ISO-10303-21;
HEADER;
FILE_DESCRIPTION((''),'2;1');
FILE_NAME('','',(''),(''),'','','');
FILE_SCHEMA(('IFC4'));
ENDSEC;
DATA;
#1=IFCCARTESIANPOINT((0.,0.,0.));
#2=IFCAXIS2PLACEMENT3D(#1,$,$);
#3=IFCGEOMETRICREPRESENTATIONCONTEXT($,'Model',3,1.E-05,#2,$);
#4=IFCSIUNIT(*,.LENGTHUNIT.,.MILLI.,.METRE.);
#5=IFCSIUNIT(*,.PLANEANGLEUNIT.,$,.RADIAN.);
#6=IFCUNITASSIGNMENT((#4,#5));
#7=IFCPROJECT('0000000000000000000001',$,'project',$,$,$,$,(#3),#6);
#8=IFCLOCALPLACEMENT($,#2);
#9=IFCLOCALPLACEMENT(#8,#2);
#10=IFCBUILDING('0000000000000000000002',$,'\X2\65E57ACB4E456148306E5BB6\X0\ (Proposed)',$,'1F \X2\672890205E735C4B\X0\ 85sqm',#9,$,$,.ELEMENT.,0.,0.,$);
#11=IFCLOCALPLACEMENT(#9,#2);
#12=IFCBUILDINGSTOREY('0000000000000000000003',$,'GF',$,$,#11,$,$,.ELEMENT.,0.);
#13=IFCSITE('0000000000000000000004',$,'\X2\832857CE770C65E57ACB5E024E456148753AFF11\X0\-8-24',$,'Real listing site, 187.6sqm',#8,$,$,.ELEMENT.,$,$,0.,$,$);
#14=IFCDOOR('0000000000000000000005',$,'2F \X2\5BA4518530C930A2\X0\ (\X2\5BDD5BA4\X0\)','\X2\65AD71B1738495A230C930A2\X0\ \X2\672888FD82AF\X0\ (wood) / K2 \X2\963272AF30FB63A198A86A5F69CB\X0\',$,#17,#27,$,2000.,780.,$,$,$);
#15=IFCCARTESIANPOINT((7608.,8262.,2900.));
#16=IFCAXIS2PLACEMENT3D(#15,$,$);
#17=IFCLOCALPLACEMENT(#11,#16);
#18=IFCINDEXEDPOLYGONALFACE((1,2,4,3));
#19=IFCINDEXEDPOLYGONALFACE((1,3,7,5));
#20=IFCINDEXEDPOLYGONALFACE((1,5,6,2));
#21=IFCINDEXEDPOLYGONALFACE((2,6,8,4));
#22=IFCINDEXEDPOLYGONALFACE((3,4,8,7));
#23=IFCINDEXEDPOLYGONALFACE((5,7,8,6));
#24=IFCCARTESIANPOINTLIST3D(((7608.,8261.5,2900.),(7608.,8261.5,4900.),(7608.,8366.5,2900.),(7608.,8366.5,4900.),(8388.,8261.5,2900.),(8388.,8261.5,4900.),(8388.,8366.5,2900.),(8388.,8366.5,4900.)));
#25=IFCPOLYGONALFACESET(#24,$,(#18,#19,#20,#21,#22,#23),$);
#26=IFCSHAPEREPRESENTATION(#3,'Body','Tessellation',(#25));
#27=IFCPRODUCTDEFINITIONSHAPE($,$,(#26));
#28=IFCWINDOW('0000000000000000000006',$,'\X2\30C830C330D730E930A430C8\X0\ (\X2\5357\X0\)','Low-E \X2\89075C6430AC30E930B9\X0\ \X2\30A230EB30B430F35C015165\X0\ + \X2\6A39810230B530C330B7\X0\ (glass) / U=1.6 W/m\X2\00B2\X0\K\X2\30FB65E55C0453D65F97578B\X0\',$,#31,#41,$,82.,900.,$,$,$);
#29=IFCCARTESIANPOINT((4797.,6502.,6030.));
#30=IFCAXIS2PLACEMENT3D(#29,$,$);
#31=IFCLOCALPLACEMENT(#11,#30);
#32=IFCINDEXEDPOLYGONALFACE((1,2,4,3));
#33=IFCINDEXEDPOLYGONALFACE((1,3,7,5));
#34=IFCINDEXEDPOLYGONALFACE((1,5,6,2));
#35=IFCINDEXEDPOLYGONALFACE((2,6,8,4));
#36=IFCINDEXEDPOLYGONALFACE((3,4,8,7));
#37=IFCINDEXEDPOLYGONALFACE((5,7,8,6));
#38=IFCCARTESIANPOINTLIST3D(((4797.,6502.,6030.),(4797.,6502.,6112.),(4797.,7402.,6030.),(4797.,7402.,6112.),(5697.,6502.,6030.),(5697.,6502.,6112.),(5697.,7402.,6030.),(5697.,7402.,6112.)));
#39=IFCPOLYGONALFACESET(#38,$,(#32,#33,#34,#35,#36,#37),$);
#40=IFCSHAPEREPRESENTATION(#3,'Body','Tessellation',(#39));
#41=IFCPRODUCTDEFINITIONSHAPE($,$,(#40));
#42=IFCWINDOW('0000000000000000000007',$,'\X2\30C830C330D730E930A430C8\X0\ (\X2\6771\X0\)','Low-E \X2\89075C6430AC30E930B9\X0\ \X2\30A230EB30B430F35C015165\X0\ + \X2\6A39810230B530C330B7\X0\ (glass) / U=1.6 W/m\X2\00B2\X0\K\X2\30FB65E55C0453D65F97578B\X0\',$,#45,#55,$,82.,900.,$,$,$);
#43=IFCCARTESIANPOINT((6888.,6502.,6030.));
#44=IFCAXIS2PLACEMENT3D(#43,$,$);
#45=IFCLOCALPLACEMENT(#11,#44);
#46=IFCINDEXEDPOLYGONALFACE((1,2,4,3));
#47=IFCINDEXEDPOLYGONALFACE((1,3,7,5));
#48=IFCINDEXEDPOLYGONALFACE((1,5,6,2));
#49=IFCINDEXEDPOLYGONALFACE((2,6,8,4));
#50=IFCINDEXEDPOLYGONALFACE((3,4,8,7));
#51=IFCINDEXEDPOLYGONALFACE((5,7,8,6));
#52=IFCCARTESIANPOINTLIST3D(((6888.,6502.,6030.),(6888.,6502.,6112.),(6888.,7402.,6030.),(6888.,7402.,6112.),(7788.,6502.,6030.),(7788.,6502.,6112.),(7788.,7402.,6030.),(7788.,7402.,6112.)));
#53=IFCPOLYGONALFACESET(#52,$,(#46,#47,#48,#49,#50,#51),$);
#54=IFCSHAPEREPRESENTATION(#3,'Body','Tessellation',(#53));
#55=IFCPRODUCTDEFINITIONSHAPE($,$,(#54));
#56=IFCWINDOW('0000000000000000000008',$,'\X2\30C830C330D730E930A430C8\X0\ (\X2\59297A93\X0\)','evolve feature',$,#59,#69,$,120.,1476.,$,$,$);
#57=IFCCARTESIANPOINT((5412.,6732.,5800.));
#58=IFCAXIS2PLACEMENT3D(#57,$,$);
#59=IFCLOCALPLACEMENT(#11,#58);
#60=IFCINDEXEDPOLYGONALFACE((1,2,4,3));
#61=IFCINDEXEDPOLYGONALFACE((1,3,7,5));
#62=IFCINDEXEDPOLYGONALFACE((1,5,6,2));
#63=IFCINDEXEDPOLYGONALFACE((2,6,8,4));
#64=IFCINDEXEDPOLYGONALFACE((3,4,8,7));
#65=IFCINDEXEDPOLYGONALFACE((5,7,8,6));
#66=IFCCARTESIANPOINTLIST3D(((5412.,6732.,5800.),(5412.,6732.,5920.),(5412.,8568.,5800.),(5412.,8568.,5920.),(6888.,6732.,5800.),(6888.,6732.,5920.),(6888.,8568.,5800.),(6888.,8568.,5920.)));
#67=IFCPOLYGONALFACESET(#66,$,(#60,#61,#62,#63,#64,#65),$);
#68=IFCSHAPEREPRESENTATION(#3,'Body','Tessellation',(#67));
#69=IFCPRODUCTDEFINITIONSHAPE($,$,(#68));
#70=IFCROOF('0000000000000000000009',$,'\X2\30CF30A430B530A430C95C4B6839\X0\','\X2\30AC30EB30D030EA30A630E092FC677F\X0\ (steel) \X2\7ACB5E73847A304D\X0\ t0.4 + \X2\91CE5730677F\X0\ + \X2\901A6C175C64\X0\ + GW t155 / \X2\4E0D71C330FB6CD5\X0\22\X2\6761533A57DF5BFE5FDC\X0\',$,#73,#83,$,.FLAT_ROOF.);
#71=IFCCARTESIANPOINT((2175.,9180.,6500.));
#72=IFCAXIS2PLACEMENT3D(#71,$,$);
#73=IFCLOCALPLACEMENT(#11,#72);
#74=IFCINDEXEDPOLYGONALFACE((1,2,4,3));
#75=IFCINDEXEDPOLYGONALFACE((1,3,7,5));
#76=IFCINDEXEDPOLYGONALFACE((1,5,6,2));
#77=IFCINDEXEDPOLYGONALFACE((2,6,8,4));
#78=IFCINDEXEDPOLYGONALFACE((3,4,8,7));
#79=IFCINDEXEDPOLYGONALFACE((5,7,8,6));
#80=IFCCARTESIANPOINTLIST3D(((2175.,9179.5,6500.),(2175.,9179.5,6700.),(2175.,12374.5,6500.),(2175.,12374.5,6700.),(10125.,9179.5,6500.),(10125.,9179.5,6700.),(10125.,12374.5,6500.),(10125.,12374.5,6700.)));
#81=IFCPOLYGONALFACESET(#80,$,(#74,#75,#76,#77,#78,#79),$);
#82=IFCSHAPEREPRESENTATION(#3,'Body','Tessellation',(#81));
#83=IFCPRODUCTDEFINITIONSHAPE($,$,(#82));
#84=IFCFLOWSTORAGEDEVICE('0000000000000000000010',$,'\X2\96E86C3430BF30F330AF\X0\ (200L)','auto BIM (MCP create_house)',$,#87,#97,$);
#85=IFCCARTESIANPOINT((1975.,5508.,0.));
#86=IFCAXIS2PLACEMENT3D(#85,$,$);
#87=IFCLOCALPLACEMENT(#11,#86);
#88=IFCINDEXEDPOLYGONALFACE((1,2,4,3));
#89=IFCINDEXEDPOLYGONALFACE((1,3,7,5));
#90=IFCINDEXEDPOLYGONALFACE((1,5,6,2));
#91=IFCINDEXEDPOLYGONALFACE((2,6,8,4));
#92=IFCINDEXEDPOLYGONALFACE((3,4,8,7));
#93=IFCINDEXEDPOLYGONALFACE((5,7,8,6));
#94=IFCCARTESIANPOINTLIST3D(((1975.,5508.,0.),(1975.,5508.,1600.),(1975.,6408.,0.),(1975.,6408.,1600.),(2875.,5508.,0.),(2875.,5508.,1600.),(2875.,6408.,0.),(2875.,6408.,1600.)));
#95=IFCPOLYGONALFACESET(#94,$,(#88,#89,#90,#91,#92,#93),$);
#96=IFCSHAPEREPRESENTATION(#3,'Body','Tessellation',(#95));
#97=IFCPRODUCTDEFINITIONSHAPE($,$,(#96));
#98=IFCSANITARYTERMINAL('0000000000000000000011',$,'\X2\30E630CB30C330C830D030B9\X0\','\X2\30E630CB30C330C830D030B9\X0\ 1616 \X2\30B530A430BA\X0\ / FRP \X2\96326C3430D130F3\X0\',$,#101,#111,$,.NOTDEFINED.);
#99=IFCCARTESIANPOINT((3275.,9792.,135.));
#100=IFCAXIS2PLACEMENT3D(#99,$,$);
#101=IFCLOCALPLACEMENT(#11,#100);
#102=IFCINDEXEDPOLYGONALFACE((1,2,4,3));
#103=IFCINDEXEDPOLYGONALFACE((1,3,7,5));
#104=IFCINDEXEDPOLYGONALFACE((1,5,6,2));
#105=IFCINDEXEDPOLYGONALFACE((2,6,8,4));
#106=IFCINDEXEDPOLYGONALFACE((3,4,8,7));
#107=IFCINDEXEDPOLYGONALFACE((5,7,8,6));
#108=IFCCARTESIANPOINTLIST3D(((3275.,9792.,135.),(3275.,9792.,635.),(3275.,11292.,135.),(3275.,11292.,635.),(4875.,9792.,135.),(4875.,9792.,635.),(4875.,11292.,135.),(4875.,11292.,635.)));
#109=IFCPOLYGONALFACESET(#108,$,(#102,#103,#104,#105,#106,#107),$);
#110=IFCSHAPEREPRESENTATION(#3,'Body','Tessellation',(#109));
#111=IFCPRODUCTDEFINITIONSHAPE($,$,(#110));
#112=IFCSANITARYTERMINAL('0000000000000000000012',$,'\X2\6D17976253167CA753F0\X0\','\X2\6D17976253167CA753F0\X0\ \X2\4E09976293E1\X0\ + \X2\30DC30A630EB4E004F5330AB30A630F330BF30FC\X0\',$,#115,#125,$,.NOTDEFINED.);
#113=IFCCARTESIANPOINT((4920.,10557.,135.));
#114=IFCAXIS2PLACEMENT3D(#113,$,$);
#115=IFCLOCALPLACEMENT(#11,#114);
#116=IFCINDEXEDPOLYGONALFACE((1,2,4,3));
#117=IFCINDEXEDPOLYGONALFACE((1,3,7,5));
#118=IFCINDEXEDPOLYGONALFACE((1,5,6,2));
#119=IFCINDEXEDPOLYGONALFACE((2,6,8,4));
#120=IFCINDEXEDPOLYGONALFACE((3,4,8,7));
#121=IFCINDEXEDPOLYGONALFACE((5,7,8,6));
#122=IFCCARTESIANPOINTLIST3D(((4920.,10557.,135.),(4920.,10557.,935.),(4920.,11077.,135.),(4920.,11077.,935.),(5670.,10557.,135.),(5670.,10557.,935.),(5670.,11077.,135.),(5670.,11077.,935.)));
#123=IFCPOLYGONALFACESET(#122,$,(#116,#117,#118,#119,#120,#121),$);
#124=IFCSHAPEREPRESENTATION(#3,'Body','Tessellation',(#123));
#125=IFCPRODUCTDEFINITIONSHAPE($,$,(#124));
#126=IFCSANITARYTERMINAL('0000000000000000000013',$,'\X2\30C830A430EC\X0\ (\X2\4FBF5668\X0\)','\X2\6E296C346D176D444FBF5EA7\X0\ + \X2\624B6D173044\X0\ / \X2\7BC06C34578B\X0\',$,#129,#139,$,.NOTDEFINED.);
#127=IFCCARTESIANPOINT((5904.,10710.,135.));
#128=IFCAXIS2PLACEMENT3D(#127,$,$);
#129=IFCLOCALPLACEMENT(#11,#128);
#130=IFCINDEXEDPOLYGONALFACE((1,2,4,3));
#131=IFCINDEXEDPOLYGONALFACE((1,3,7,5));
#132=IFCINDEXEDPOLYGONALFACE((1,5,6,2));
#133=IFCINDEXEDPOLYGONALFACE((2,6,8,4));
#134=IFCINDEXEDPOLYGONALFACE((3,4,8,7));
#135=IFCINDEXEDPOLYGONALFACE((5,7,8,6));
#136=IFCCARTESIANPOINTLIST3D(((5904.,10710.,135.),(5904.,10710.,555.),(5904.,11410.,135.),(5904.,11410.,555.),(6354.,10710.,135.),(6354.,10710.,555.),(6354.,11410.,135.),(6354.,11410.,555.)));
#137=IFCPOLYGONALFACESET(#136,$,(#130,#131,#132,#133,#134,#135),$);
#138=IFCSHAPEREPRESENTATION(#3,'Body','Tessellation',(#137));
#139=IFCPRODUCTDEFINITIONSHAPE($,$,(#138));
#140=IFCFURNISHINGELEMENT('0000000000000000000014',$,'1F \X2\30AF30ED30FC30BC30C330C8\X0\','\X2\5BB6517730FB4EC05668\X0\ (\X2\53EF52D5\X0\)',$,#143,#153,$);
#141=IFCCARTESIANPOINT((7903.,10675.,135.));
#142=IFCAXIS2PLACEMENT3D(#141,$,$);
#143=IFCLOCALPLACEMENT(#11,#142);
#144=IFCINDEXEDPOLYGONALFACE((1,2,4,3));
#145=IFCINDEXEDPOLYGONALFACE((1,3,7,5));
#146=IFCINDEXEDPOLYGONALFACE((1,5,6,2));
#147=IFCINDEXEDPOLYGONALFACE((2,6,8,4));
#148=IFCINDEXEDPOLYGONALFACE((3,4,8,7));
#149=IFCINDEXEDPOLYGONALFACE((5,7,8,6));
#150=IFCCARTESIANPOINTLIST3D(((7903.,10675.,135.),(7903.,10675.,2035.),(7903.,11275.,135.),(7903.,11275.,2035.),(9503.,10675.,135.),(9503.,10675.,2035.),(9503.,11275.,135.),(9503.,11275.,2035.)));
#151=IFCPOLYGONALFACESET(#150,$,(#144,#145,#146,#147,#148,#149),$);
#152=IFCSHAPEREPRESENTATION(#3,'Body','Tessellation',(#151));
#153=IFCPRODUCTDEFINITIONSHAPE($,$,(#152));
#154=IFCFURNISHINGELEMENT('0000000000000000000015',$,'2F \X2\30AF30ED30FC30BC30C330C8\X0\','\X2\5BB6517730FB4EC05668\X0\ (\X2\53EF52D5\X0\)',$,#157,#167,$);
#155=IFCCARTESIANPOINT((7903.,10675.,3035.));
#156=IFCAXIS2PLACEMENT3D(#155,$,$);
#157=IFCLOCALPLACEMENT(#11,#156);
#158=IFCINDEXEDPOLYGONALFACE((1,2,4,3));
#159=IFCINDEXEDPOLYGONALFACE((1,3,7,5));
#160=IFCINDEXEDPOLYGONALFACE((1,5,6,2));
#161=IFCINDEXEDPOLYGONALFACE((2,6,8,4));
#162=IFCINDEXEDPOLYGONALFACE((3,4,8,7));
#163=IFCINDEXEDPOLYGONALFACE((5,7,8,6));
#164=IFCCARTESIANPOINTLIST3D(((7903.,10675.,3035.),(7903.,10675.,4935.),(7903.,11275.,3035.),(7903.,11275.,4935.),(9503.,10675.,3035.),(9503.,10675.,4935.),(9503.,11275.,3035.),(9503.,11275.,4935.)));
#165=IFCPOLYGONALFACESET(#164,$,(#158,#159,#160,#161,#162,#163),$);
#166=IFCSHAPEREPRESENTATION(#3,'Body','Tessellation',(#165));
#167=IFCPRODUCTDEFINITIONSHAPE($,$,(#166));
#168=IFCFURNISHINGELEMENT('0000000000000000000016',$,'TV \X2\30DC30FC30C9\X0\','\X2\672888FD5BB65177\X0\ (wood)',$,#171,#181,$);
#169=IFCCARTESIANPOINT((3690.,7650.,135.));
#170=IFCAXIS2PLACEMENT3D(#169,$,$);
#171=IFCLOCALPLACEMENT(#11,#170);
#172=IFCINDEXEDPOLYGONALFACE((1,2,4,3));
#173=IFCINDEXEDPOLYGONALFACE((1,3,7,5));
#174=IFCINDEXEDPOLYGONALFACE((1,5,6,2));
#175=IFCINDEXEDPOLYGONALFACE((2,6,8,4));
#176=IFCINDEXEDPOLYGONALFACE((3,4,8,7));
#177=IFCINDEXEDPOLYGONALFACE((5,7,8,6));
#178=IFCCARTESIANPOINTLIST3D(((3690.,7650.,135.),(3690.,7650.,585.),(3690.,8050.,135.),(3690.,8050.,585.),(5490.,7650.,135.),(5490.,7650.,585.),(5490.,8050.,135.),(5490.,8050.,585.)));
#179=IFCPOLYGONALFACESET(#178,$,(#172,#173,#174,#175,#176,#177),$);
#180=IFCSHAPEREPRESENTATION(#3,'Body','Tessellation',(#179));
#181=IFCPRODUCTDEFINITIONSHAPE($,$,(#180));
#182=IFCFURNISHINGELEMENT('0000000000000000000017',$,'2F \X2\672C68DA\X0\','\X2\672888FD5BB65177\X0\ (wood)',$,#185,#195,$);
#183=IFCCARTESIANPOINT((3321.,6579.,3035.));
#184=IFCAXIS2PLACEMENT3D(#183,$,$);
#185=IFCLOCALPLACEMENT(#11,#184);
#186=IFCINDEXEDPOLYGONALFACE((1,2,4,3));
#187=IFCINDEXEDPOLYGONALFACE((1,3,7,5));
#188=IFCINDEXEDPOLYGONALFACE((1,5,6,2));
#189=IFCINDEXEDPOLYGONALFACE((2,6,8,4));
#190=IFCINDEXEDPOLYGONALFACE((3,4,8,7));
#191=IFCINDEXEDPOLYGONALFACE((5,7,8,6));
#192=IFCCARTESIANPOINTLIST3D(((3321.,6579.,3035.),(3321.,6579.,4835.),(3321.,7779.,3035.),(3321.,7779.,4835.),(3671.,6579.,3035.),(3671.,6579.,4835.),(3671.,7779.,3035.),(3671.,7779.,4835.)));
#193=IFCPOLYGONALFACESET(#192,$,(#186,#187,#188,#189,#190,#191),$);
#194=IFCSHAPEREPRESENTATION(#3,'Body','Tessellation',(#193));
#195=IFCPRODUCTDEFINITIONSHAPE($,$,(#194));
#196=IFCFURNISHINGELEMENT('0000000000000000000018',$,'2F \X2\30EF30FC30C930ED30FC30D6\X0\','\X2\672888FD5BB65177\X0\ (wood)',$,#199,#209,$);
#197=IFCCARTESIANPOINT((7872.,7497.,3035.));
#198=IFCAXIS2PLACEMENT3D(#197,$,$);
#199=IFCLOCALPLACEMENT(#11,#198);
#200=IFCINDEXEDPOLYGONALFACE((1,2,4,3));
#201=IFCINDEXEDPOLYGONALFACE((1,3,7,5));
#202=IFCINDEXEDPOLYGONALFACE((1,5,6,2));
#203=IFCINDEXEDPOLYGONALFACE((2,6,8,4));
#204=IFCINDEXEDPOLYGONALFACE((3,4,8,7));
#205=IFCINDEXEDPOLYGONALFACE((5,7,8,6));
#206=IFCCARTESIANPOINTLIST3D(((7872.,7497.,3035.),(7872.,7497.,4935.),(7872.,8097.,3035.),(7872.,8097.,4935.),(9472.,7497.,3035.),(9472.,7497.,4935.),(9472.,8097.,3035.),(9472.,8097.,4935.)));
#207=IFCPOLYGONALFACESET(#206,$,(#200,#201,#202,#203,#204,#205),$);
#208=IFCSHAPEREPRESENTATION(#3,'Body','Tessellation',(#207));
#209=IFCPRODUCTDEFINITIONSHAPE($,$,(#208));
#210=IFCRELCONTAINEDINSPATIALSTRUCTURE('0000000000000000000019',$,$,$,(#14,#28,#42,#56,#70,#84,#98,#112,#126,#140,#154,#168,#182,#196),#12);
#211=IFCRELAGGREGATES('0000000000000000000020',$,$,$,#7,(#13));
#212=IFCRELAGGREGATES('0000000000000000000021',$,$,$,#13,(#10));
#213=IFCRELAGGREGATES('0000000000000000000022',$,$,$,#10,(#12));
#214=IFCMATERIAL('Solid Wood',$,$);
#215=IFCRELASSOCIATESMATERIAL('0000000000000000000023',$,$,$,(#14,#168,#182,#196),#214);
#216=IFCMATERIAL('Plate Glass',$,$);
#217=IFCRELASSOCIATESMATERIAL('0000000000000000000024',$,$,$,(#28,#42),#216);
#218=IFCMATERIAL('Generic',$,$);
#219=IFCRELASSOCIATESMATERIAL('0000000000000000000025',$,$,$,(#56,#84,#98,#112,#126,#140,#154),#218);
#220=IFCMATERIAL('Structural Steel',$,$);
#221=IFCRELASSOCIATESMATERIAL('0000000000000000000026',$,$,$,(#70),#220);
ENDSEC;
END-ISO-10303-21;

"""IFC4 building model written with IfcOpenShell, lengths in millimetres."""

from ifc_helpers import new_model, si_unit, frame, frame_2d, origin, place, context, project, spatial, rectangle, extrude, material, element, save


model = new_model("IFC4")

# Units and contexts
model_context = context("Model", 3, precision=1e-05, world=origin())
ifc_project = project(units=[si_unit("LENGTHUNIT", "METRE", prefix="MILLI"), si_unit("PLANEANGLEUNIT", "RADIAN")], contexts=[model_context])

# Site, building, storey
site_placement = place(None, origin())
site = spatial("IfcSite", under=ifc_project, at=site_placement, Name="茨城県日立市久慈町１-8-24", ObjectType="Real listing site, 187.6sqm", CompositionType="ELEMENT", RefElevation=0.0)
building_placement = place(site_placement, origin())
building = spatial("IfcBuilding", under=site, at=building_placement, Name="日立久慈の家 (Proposed)", ObjectType="1F 木造平屋 85sqm", CompositionType="ELEMENT", ElevationOfRefHeight=0.0, ElevationOfTerrain=0.0)
storey_placement = place(building_placement, origin())
storey = spatial("IfcBuildingStorey", under=building, at=storey_placement, Name="GF", CompositionType="ELEMENT", Elevation=0.0)

# Shared definitions
ifc_material_1 = material(Name="Solid Wood")
ifc_material_2 = material(Name="Plate Glass")

# Door
door_1_placement = place(storey_placement, frame((7608.0, 8262.0, 2900.0)))
element("IfcDoor", 1, at=door_1_placement, inside=storey, material=ifc_material_1, Name="2F 室内ドア (寝室)", Description="断熱玄関ドア 木製芯 (wood) / K2 防犯・採風機構", OverallHeight=2000.0, OverallWidth=780.0, context=model_context, shape_type="SweptSolid", body=[
    extrude(rectangle(XDim=780.0, YDim=105.0, at=frame_2d((390.0, 52.0))), frame((7608.0, 8262.0, 2900.0)), (0.0, 0.0, 1.0), 2000.0),
])

# Windows
window_1_placement = place(storey_placement, frame((4797.0, 6502.0, 6030.0)))
element("IfcWindow", 2, at=window_1_placement, inside=storey, material=ifc_material_2, Name="トップライト (南)", Description="Low-E 複層ガラス アルゴン封入 + 樹脂サッシ (glass) / U=1.6 W/m²K・日射取得型", OverallHeight=82.0, OverallWidth=900.0, context=model_context, shape_type="SweptSolid", body=[
    extrude(rectangle(XDim=900.0, YDim=900.0, at=frame_2d((450.0, 450.0))), frame((4797.0, 6502.0, 6030.0)), (0.0, 0.0, 1.0), 82.0),
])
window_2_placement = place(storey_placement, frame((6888.0, 6502.0, 6030.0)))
element("IfcWindow", 3, at=window_2_placement, inside=storey, material=ifc_material_2, Name="トップライト (東)", Description="Low-E 複層ガラス アルゴン封入 + 樹脂サッシ (glass) / U=1.6 W/m²K・日射取得型", OverallHeight=82.0, OverallWidth=900.0, context=model_context, shape_type="SweptSolid", body=[
    extrude(rectangle(XDim=900.0, YDim=900.0, at=frame_2d((450.0, 450.0))), frame((6888.0, 6502.0, 6030.0)), (0.0, 0.0, 1.0), 82.0),
])
ifc_material_3 = material(Name="Generic")
window_3_placement = place(storey_placement, frame((5412.0, 6732.0, 5800.0)))
element("IfcWindow", 4, at=window_3_placement, inside=storey, material=ifc_material_3, Name="トップライト (天窓)", Description="evolve feature", OverallHeight=120.0, OverallWidth=1476.0, context=model_context, shape_type="SweptSolid", body=[
    extrude(rectangle(XDim=1476.0, YDim=1836.0, at=frame_2d((738.0, 918.0))), frame((5412.0, 6732.0, 5800.0)), (0.0, 0.0, 1.0), 120.0),
])

# Roof
ifc_material_4 = material(Name="Structural Steel")
roof_placement = place(storey_placement, frame((2175.0, 9180.0, 6500.0)))
element("IfcRoof", 5, at=roof_placement, inside=storey, material=ifc_material_4, Name="ハイサイド屋根", Description="ガルバリウム鋼板 (steel) 立平葺き t0.4 + 野地板 + 通気層 + GW t155 / 不燃・法22条区域対応", PredefinedType="FLAT_ROOF", context=model_context, shape_type="SweptSolid", body=[
    extrude(rectangle(XDim=7950.0, YDim=3195.0, at=frame_2d((3975.0, 1597.0))), frame((2175.0, 9180.0, 6500.0)), (0.0, 0.0, 1.0), 200.0),
])

# Flow storage device
flow_storage_device_placement = place(storey_placement, frame((1975.0, 5508.0, 0.0)))
element("IfcFlowStorageDevice", 6, at=flow_storage_device_placement, inside=storey, material=ifc_material_3, Name="雨水タンク (200L)", Description="auto BIM (MCP create_house)", context=model_context, shape_type="SweptSolid", body=[
    extrude(rectangle(XDim=900.0, YDim=900.0, at=frame_2d((450.0, 450.0))), frame((1975.0, 5508.0, 0.0)), (0.0, 0.0, 1.0), 1600.0),
])

# Sanitary terminals
sanitary_terminal_1_placement = place(storey_placement, frame((3275.0, 9792.0, 135.0)))
element("IfcSanitaryTerminal", 7, at=sanitary_terminal_1_placement, inside=storey, material=ifc_material_3, Name="ユニットバス", Description="ユニットバス 1616 サイズ / FRP 防水パン", PredefinedType="NOTDEFINED", context=model_context, shape_type="SweptSolid", body=[
    extrude(rectangle(XDim=1600.0, YDim=1500.0, at=frame_2d((800.0, 750.0))), frame((3275.0, 9792.0, 135.0)), (0.0, 0.0, 1.0), 500.0),
])
sanitary_terminal_2_placement = place(storey_placement, frame((4920.0, 10557.0, 135.0)))
element("IfcSanitaryTerminal", 8, at=sanitary_terminal_2_placement, inside=storey, material=ifc_material_3, Name="洗面化粧台", Description="洗面化粧台 三面鏡 + ボウル一体カウンター", PredefinedType="NOTDEFINED", context=model_context, shape_type="SweptSolid", body=[
    extrude(rectangle(XDim=750.0, YDim=520.0, at=frame_2d((375.0, 260.0))), frame((4920.0, 10557.0, 135.0)), (0.0, 0.0, 1.0), 800.0),
])
sanitary_terminal_3_placement = place(storey_placement, frame((5904.0, 10710.0, 135.0)))
element("IfcSanitaryTerminal", 9, at=sanitary_terminal_3_placement, inside=storey, material=ifc_material_3, Name="トイレ (便器)", Description="温水洗浄便座 + 手洗い / 節水型", PredefinedType="NOTDEFINED", context=model_context, shape_type="SweptSolid", body=[
    extrude(rectangle(XDim=450.0, YDim=700.0, at=frame_2d((225.0, 350.0))), frame((5904.0, 10710.0, 135.0)), (0.0, 0.0, 1.0), 420.0),
])

# Furnishing elements
furnishing_1_placement = place(storey_placement, frame((7903.0, 10675.0, 135.0)))
element("IfcFurnishingElement", 10, at=furnishing_1_placement, inside=storey, material=ifc_material_3, Name="1F クローゼット", Description="家具・什器 (可動)", context=model_context, shape_type="SweptSolid", body=[
    extrude(rectangle(XDim=1600.0, YDim=600.0, at=frame_2d((800.0, 300.0))), frame((7903.0, 10675.0, 135.0)), (0.0, 0.0, 1.0), 1900.0),
])
furnishing_2_placement = place(storey_placement, frame((7903.0, 10675.0, 3035.0)))
element("IfcFurnishingElement", 11, at=furnishing_2_placement, inside=storey, material=ifc_material_3, Name="2F クローゼット", Description="家具・什器 (可動)", context=model_context, shape_type="SweptSolid", body=[
    extrude(rectangle(XDim=1600.0, YDim=600.0, at=frame_2d((800.0, 300.0))), frame((7903.0, 10675.0, 3035.0)), (0.0, 0.0, 1.0), 1900.0),
])
furnishing_3_placement = place(storey_placement, frame((3690.0, 7650.0, 135.0)))
element("IfcFurnishingElement", 12, at=furnishing_3_placement, inside=storey, material=ifc_material_1, Name="TV ボード", Description="木製家具 (wood)", context=model_context, shape_type="SweptSolid", body=[
    extrude(rectangle(XDim=1800.0, YDim=400.0, at=frame_2d((900.0, 200.0))), frame((3690.0, 7650.0, 135.0)), (0.0, 0.0, 1.0), 450.0),
])
furnishing_4_placement = place(storey_placement, frame((3321.0, 6579.0, 3035.0)))
element("IfcFurnishingElement", 13, at=furnishing_4_placement, inside=storey, material=ifc_material_1, Name="2F 本棚", Description="木製家具 (wood)", context=model_context, shape_type="SweptSolid", body=[
    extrude(rectangle(XDim=350.0, YDim=1200.0, at=frame_2d((175.0, 600.0))), frame((3321.0, 6579.0, 3035.0)), (0.0, 0.0, 1.0), 1800.0),
])
furnishing_5_placement = place(storey_placement, frame((7872.0, 7497.0, 3035.0)))
element("IfcFurnishingElement", 14, at=furnishing_5_placement, inside=storey, material=ifc_material_1, Name="2F ワードローブ", Description="木製家具 (wood)", context=model_context, shape_type="SweptSolid", body=[
    extrude(rectangle(XDim=1600.0, YDim=600.0, at=frame_2d((800.0, 300.0))), frame((7872.0, 7497.0, 3035.0)), (0.0, 0.0, 1.0), 1900.0),
])

save(model, "model.ifc")
